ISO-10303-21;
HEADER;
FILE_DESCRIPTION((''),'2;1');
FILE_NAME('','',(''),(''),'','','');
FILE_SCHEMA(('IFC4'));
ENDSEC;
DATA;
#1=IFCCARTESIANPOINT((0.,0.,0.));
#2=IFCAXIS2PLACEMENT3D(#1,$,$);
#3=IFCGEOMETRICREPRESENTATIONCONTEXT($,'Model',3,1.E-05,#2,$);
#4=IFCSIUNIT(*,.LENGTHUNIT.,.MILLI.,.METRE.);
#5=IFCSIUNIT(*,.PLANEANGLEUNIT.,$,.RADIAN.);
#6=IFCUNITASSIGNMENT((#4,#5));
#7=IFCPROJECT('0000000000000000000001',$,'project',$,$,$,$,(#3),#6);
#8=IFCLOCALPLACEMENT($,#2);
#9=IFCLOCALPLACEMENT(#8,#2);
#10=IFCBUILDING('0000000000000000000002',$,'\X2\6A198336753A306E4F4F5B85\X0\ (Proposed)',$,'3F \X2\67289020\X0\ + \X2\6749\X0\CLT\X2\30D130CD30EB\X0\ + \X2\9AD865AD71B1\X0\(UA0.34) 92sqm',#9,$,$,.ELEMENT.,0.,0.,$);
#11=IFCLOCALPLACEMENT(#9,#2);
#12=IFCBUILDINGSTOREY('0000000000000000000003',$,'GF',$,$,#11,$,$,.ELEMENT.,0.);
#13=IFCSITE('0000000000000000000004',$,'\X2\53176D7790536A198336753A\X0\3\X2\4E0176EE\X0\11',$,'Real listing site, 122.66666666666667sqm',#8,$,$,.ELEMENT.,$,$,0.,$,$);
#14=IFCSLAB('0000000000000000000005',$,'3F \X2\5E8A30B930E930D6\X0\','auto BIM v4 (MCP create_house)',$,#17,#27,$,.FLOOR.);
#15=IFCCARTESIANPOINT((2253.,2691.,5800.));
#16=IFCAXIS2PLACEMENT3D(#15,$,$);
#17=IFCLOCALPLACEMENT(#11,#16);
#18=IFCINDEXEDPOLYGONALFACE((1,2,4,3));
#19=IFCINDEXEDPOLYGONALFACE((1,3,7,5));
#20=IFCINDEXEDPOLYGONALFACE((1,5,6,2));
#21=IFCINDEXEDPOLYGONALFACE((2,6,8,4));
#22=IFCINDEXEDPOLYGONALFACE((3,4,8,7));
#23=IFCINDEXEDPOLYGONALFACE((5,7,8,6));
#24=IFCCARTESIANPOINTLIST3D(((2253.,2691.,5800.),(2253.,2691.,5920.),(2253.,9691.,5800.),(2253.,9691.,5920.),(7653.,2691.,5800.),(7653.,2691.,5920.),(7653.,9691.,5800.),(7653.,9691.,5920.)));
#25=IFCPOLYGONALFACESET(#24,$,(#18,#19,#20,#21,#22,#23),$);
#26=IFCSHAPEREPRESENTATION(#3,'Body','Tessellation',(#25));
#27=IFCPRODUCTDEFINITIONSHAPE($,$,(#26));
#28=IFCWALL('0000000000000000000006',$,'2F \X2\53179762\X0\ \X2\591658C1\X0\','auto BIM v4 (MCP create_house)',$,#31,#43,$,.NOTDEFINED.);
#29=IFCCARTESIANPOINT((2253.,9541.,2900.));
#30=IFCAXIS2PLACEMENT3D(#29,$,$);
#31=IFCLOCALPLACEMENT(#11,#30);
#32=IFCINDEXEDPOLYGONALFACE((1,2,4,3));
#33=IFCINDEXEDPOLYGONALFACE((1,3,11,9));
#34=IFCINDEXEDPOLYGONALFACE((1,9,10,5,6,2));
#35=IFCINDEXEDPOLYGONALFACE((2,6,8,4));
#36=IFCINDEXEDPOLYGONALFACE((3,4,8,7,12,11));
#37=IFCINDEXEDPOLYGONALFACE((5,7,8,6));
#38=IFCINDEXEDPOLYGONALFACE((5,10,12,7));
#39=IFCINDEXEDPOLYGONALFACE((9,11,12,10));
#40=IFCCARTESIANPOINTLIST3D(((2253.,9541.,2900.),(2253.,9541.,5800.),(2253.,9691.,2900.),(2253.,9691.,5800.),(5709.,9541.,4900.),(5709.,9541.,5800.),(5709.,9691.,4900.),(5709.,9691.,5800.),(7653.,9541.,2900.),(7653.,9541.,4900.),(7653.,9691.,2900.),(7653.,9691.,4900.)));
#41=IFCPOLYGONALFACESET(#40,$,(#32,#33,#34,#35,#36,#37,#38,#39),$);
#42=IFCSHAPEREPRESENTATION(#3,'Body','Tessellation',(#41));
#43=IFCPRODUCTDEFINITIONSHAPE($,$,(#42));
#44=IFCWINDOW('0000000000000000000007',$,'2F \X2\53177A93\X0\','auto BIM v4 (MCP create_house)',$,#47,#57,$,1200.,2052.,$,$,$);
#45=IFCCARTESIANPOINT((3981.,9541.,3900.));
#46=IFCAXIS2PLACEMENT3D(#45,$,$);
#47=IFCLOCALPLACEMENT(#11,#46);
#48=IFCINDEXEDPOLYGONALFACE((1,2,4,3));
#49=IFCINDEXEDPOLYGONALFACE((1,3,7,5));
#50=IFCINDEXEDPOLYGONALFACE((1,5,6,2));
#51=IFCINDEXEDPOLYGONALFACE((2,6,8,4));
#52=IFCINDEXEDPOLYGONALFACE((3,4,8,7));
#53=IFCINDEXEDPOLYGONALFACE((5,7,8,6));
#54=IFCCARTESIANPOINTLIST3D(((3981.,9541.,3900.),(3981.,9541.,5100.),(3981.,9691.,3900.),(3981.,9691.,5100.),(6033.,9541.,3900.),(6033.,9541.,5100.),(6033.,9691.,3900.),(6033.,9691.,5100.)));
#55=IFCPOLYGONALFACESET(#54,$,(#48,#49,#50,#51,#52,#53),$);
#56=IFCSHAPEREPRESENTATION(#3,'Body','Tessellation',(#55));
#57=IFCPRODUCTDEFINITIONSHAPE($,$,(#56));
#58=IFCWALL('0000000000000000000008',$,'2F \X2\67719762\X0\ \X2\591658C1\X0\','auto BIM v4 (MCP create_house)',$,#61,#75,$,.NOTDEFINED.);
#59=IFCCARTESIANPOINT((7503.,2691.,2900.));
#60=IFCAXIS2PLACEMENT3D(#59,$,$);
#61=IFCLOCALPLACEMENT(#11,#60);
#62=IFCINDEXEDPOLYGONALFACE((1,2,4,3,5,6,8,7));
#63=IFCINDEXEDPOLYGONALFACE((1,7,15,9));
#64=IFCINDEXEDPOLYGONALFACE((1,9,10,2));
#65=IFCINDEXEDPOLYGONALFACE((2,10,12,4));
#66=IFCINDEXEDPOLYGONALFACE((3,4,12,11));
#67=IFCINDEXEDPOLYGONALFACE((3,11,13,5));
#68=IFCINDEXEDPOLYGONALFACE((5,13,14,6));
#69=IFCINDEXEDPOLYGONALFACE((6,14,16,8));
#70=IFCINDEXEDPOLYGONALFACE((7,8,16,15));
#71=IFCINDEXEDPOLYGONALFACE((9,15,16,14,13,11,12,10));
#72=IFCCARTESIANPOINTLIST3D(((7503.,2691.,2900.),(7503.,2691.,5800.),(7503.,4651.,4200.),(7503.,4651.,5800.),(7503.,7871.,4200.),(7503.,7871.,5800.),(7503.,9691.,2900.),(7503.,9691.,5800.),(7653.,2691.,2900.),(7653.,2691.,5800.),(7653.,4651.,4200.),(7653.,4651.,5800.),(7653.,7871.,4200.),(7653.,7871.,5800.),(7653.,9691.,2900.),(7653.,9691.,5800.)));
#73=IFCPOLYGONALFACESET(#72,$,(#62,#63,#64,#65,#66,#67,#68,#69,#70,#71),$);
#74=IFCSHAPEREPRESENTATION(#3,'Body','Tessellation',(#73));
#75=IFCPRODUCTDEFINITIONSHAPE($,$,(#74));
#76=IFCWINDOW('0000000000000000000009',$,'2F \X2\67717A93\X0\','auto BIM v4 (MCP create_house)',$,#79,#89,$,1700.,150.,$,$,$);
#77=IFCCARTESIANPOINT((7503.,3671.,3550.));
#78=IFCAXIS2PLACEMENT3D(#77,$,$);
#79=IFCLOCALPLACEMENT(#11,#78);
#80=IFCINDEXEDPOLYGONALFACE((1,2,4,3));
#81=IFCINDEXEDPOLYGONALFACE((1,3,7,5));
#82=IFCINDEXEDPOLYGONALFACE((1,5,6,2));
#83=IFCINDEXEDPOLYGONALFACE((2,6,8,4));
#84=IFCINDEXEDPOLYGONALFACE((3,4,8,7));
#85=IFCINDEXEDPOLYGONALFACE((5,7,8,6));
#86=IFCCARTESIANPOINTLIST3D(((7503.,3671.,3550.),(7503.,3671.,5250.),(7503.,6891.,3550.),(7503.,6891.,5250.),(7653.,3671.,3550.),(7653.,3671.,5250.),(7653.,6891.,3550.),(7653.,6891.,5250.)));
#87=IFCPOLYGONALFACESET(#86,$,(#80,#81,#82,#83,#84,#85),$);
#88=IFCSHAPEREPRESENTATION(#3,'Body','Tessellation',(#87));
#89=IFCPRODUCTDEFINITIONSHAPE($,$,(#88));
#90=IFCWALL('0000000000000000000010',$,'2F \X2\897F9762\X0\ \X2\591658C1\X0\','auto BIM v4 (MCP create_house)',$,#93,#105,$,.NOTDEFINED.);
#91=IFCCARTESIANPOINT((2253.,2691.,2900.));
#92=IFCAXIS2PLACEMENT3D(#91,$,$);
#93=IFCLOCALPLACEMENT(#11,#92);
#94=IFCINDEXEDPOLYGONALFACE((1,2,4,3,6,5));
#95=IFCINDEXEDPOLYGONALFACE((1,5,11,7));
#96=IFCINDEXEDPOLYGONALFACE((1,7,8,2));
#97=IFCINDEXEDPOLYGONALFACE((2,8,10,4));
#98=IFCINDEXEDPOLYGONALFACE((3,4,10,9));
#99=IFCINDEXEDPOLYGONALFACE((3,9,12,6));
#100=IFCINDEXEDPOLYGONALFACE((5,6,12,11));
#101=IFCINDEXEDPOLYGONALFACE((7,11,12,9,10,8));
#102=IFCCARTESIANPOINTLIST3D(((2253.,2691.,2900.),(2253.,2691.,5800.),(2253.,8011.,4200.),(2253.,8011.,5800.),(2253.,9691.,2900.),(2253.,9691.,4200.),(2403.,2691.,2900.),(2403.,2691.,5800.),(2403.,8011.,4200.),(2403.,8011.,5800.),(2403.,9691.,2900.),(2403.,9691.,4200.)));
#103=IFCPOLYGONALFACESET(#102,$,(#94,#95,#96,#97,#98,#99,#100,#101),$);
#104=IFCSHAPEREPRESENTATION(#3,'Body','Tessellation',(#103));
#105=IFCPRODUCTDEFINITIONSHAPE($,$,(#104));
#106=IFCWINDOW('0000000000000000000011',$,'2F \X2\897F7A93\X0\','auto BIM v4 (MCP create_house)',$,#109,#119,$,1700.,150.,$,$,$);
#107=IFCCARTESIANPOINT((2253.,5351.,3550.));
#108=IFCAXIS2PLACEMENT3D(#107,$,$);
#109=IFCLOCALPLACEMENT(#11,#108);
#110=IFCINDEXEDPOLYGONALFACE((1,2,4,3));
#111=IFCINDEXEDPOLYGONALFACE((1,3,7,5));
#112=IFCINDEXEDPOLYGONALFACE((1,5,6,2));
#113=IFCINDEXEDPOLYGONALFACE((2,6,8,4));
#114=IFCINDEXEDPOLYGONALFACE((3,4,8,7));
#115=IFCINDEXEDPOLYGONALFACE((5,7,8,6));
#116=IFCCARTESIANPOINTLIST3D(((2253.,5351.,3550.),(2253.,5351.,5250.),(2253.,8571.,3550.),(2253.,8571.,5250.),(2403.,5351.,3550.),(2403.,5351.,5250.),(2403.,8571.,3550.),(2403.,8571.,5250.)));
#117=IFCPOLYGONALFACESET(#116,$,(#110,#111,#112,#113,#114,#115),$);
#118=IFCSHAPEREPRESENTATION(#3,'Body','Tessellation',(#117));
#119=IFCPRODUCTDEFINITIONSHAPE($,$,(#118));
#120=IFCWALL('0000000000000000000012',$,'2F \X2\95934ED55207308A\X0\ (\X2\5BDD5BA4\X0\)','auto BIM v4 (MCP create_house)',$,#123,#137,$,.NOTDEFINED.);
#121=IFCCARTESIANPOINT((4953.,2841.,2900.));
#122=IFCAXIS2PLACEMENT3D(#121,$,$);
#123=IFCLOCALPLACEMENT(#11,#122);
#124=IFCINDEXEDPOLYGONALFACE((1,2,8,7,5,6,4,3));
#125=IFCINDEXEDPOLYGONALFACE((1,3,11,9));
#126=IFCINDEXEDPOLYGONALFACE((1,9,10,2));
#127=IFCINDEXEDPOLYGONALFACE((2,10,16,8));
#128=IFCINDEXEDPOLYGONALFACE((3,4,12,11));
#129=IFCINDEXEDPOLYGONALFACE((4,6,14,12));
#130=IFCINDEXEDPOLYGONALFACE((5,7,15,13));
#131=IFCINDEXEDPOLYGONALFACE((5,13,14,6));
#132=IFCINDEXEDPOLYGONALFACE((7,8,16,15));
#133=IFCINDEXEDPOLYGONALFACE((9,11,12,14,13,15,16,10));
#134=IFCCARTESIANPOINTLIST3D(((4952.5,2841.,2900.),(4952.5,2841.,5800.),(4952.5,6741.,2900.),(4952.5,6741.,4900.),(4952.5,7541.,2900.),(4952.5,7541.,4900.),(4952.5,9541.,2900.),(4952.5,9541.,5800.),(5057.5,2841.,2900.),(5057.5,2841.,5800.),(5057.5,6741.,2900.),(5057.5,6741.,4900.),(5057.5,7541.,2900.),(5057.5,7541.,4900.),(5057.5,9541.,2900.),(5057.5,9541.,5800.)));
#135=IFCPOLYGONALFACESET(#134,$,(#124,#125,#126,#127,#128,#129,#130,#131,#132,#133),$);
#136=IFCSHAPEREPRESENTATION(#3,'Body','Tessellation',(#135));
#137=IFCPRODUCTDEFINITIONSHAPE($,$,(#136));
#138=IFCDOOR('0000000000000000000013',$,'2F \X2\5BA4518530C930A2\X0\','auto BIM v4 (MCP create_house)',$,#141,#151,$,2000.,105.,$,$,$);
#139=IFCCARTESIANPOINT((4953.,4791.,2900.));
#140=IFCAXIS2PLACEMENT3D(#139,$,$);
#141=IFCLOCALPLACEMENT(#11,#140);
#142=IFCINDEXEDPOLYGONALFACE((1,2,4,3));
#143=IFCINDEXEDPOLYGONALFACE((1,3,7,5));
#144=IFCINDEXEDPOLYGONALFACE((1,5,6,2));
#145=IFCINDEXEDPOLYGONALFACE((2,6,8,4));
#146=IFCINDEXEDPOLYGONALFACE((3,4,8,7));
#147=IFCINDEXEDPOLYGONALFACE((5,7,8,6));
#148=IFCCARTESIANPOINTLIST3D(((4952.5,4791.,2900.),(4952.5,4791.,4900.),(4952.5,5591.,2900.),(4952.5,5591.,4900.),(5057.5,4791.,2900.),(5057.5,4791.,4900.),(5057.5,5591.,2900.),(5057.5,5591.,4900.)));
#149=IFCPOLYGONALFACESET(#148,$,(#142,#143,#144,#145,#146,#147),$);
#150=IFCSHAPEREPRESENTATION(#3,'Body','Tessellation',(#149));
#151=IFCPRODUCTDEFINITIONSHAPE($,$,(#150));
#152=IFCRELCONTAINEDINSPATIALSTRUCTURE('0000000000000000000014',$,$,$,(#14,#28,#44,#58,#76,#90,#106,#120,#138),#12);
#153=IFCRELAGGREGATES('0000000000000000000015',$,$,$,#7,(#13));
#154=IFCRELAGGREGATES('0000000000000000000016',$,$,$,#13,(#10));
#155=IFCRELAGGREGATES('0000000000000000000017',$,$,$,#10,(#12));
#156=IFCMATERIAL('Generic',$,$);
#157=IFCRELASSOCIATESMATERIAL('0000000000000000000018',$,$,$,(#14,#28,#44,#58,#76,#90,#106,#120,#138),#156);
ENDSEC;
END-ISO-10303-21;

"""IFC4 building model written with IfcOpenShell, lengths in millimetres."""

from ifc_helpers import new_model, si_unit, frame, frame_2d, origin, place, context, project, spatial, rectangle, extrude, material, element, fill, save


model = new_model("IFC4")

# Units and contexts
model_context = context("Model", 3, precision=1e-05, world=origin())
ifc_project = project(units=[si_unit("LENGTHUNIT", "METRE", prefix="MILLI"), si_unit("PLANEANGLEUNIT", "RADIAN")], contexts=[model_context])

# Site, building, storey
site_placement = place(None, origin())
site = spatial("IfcSite", under=ifc_project, at=site_placement, Name="北海道標茶町3丁目11", ObjectType="Real listing site, 122.66666666666667sqm", CompositionType="ELEMENT", RefElevation=0.0)
building_placement = place(site_placement, origin())
building = spatial("IfcBuilding", under=site, at=building_placement, Name="標茶町の住宅 (Proposed)", ObjectType="3F 木造 + 杉CLTパネル + 高断熱(UA0.34) 92sqm", CompositionType="ELEMENT", ElevationOfRefHeight=0.0, ElevationOfTerrain=0.0)
storey_placement = place(building_placement, origin())
storey = spatial("IfcBuildingStorey", under=building, at=storey_placement, Name="GF", CompositionType="ELEMENT", Elevation=0.0)

# Slab
ifc_material = material(Name="Generic")
slab_placement = place(storey_placement, frame((2253.0, 2691.0, 5800.0)))
element("IfcSlab", 1, at=slab_placement, inside=storey, material=ifc_material, Name="3F 床スラブ", Description="auto BIM v4 (MCP create_house)", PredefinedType="FLOOR", context=model_context, shape_type="SweptSolid", body=[
    extrude(rectangle(XDim=5400.0, YDim=7000.0, at=frame_2d((2700.0, 3500.0))), frame((2253.0, 2691.0, 5800.0)), (0.0, 0.0, 1.0), 120.0),
])

# Walls, openings, windows
wall_1_placement = place(storey_placement, frame((2253.0, 9541.0, 2900.0)))
wall_1 = element("IfcWall", 2, at=wall_1_placement, inside=storey, material=ifc_material, Name="2F 北面 外壁", Description="auto BIM v4 (MCP create_house)", PredefinedType="NOTDEFINED", context=model_context, shape_type="SweptSolid", body=[
    extrude(rectangle(XDim=5400.0, YDim=150.0, at=frame_2d((2700.0, 75.0))), frame((2253.0, 9541.0, 2900.0)), (0.0, 0.0, 1.0), 2900.0),
])
opening_1_placement = place(storey_placement, frame((3981.0, 9541.0, 3900.0)))
opening_1 = element("IfcOpeningElement", 3, at=opening_1_placement, cuts=wall_1, PredefinedType="NOTDEFINED", context=model_context, shape_type="SweptSolid", body=[
    extrude(rectangle(XDim=2052.0, YDim=150.0, at=frame_2d((1026.0, 75.0))), frame((3981.0, 9541.0, 3900.0)), (0.0, 0.0, 1.0), 1200.0),
])
window_1_placement = place(storey_placement, frame((3981.0, 9541.0, 3900.0)))
window_1 = element("IfcWindow", 4, at=window_1_placement, inside=storey, material=ifc_material, Name="2F 北窓", Description="auto BIM v4 (MCP create_house)", OverallHeight=1200.0, OverallWidth=2052.0, context=model_context, shape_type="SweptSolid", body=[
    extrude(rectangle(XDim=2052.0, YDim=150.0, at=frame_2d((1026.0, 75.0))), frame((3981.0, 9541.0, 3900.0)), (0.0, 0.0, 1.0), 1200.0),
])
fill(opening_1, window_1)
wall_2_placement = place(storey_placement, frame((7503.0, 2691.0, 2900.0)))
wall_2 = element("IfcWall", 5, at=wall_2_placement, inside=storey, material=ifc_material, Name="2F 東面 外壁", Description="auto BIM v4 (MCP create_house)", PredefinedType="NOTDEFINED", context=model_context, shape_type="SweptSolid", body=[
    extrude(rectangle(XDim=150.0, YDim=7000.0, at=frame_2d((75.0, 3500.0))), frame((7503.0, 2691.0, 2900.0)), (0.0, 0.0, 1.0), 2900.0),
])
opening_2_placement = place(storey_placement, frame((7503.0, 3671.0, 3550.0)))
opening_2 = element("IfcOpeningElement", 6, at=opening_2_placement, cuts=wall_2, PredefinedType="NOTDEFINED", context=model_context, shape_type="SweptSolid", body=[
    extrude(rectangle(XDim=150.0, YDim=3220.0, at=frame_2d((75.0, 1610.0))), frame((7503.0, 3671.0, 3550.0)), (0.0, 0.0, 1.0), 1700.0),
])
window_2_placement = place(storey_placement, frame((7503.0, 3671.0, 3550.0)))
window_2 = element("IfcWindow", 7, at=window_2_placement, inside=storey, material=ifc_material, Name="2F 東窓", Description="auto BIM v4 (MCP create_house)", OverallHeight=1700.0, OverallWidth=150.0, context=model_context, shape_type="SweptSolid", body=[
    extrude(rectangle(XDim=150.0, YDim=3220.0, at=frame_2d((75.0, 1610.0))), frame((7503.0, 3671.0, 3550.0)), (0.0, 0.0, 1.0), 1700.0),
])
fill(opening_2, window_2)
wall_3_placement = place(storey_placement, frame((2253.0, 2691.0, 2900.0)))
wall_3 = element("IfcWall", 8, at=wall_3_placement, inside=storey, material=ifc_material, Name="2F 西面 外壁", Description="auto BIM v4 (MCP create_house)", PredefinedType="NOTDEFINED", context=model_context, shape_type="SweptSolid", body=[
    extrude(rectangle(XDim=150.0, YDim=7000.0, at=frame_2d((75.0, 3500.0))), frame((2253.0, 2691.0, 2900.0)), (0.0, 0.0, 1.0), 2900.0),
])
opening_3_placement = place(storey_placement, frame((2253.0, 5351.0, 3550.0)))
opening_3 = element("IfcOpeningElement", 9, at=opening_3_placement, cuts=wall_3, PredefinedType="NOTDEFINED", context=model_context, shape_type="SweptSolid", body=[
    extrude(rectangle(XDim=150.0, YDim=3220.0, at=frame_2d((75.0, 1610.0))), frame((2253.0, 5351.0, 3550.0)), (0.0, 0.0, 1.0), 1700.0),
])
window_3_placement = place(storey_placement, frame((2253.0, 5351.0, 3550.0)))
window_3 = element("IfcWindow", 10, at=window_3_placement, inside=storey, material=ifc_material, Name="2F 西窓", Description="auto BIM v4 (MCP create_house)", OverallHeight=1700.0, OverallWidth=150.0, context=model_context, shape_type="SweptSolid", body=[
    extrude(rectangle(XDim=150.0, YDim=3220.0, at=frame_2d((75.0, 1610.0))), frame((2253.0, 5351.0, 3550.0)), (0.0, 0.0, 1.0), 1700.0),
])
fill(opening_3, window_3)

# Wall, opening, door
wall_4_placement = place(storey_placement, frame((4953.0, 2841.0, 2900.0)))
wall_4 = element("IfcWall", 11, at=wall_4_placement, inside=storey, material=ifc_material, Name="2F 間仕切り (寝室)", Description="auto BIM v4 (MCP create_house)", PredefinedType="NOTDEFINED", context=model_context, shape_type="SweptSolid", body=[
    extrude(rectangle(XDim=105.0, YDim=6700.0, at=frame_2d((52.0, 3350.0))), frame((4953.0, 2841.0, 2900.0)), (0.0, 0.0, 1.0), 2900.0),
])
opening_4_placement = place(storey_placement, frame((4953.0, 4791.0, 2900.0)))
opening_4 = element("IfcOpeningElement", 12, at=opening_4_placement, cuts=wall_4, PredefinedType="NOTDEFINED", context=model_context, shape_type="SweptSolid", body=[
    extrude(rectangle(XDim=105.0, YDim=800.0, at=frame_2d((52.0, 400.0))), frame((4953.0, 4791.0, 2900.0)), (0.0, 0.0, 1.0), 2000.0),
])
door_1_placement = place(storey_placement, frame((4953.0, 4791.0, 2900.0)))
door_1 = element("IfcDoor", 13, at=door_1_placement, inside=storey, material=ifc_material, Name="2F 室内ドア", Description="auto BIM v4 (MCP create_house)", OverallHeight=2000.0, OverallWidth=105.0, context=model_context, shape_type="SweptSolid", body=[
    extrude(rectangle(XDim=105.0, YDim=800.0, at=frame_2d((52.0, 400.0))), frame((4953.0, 4791.0, 2900.0)), (0.0, 0.0, 1.0), 2000.0),
])
fill(opening_4, door_1)

save(model, "model.ifc")
